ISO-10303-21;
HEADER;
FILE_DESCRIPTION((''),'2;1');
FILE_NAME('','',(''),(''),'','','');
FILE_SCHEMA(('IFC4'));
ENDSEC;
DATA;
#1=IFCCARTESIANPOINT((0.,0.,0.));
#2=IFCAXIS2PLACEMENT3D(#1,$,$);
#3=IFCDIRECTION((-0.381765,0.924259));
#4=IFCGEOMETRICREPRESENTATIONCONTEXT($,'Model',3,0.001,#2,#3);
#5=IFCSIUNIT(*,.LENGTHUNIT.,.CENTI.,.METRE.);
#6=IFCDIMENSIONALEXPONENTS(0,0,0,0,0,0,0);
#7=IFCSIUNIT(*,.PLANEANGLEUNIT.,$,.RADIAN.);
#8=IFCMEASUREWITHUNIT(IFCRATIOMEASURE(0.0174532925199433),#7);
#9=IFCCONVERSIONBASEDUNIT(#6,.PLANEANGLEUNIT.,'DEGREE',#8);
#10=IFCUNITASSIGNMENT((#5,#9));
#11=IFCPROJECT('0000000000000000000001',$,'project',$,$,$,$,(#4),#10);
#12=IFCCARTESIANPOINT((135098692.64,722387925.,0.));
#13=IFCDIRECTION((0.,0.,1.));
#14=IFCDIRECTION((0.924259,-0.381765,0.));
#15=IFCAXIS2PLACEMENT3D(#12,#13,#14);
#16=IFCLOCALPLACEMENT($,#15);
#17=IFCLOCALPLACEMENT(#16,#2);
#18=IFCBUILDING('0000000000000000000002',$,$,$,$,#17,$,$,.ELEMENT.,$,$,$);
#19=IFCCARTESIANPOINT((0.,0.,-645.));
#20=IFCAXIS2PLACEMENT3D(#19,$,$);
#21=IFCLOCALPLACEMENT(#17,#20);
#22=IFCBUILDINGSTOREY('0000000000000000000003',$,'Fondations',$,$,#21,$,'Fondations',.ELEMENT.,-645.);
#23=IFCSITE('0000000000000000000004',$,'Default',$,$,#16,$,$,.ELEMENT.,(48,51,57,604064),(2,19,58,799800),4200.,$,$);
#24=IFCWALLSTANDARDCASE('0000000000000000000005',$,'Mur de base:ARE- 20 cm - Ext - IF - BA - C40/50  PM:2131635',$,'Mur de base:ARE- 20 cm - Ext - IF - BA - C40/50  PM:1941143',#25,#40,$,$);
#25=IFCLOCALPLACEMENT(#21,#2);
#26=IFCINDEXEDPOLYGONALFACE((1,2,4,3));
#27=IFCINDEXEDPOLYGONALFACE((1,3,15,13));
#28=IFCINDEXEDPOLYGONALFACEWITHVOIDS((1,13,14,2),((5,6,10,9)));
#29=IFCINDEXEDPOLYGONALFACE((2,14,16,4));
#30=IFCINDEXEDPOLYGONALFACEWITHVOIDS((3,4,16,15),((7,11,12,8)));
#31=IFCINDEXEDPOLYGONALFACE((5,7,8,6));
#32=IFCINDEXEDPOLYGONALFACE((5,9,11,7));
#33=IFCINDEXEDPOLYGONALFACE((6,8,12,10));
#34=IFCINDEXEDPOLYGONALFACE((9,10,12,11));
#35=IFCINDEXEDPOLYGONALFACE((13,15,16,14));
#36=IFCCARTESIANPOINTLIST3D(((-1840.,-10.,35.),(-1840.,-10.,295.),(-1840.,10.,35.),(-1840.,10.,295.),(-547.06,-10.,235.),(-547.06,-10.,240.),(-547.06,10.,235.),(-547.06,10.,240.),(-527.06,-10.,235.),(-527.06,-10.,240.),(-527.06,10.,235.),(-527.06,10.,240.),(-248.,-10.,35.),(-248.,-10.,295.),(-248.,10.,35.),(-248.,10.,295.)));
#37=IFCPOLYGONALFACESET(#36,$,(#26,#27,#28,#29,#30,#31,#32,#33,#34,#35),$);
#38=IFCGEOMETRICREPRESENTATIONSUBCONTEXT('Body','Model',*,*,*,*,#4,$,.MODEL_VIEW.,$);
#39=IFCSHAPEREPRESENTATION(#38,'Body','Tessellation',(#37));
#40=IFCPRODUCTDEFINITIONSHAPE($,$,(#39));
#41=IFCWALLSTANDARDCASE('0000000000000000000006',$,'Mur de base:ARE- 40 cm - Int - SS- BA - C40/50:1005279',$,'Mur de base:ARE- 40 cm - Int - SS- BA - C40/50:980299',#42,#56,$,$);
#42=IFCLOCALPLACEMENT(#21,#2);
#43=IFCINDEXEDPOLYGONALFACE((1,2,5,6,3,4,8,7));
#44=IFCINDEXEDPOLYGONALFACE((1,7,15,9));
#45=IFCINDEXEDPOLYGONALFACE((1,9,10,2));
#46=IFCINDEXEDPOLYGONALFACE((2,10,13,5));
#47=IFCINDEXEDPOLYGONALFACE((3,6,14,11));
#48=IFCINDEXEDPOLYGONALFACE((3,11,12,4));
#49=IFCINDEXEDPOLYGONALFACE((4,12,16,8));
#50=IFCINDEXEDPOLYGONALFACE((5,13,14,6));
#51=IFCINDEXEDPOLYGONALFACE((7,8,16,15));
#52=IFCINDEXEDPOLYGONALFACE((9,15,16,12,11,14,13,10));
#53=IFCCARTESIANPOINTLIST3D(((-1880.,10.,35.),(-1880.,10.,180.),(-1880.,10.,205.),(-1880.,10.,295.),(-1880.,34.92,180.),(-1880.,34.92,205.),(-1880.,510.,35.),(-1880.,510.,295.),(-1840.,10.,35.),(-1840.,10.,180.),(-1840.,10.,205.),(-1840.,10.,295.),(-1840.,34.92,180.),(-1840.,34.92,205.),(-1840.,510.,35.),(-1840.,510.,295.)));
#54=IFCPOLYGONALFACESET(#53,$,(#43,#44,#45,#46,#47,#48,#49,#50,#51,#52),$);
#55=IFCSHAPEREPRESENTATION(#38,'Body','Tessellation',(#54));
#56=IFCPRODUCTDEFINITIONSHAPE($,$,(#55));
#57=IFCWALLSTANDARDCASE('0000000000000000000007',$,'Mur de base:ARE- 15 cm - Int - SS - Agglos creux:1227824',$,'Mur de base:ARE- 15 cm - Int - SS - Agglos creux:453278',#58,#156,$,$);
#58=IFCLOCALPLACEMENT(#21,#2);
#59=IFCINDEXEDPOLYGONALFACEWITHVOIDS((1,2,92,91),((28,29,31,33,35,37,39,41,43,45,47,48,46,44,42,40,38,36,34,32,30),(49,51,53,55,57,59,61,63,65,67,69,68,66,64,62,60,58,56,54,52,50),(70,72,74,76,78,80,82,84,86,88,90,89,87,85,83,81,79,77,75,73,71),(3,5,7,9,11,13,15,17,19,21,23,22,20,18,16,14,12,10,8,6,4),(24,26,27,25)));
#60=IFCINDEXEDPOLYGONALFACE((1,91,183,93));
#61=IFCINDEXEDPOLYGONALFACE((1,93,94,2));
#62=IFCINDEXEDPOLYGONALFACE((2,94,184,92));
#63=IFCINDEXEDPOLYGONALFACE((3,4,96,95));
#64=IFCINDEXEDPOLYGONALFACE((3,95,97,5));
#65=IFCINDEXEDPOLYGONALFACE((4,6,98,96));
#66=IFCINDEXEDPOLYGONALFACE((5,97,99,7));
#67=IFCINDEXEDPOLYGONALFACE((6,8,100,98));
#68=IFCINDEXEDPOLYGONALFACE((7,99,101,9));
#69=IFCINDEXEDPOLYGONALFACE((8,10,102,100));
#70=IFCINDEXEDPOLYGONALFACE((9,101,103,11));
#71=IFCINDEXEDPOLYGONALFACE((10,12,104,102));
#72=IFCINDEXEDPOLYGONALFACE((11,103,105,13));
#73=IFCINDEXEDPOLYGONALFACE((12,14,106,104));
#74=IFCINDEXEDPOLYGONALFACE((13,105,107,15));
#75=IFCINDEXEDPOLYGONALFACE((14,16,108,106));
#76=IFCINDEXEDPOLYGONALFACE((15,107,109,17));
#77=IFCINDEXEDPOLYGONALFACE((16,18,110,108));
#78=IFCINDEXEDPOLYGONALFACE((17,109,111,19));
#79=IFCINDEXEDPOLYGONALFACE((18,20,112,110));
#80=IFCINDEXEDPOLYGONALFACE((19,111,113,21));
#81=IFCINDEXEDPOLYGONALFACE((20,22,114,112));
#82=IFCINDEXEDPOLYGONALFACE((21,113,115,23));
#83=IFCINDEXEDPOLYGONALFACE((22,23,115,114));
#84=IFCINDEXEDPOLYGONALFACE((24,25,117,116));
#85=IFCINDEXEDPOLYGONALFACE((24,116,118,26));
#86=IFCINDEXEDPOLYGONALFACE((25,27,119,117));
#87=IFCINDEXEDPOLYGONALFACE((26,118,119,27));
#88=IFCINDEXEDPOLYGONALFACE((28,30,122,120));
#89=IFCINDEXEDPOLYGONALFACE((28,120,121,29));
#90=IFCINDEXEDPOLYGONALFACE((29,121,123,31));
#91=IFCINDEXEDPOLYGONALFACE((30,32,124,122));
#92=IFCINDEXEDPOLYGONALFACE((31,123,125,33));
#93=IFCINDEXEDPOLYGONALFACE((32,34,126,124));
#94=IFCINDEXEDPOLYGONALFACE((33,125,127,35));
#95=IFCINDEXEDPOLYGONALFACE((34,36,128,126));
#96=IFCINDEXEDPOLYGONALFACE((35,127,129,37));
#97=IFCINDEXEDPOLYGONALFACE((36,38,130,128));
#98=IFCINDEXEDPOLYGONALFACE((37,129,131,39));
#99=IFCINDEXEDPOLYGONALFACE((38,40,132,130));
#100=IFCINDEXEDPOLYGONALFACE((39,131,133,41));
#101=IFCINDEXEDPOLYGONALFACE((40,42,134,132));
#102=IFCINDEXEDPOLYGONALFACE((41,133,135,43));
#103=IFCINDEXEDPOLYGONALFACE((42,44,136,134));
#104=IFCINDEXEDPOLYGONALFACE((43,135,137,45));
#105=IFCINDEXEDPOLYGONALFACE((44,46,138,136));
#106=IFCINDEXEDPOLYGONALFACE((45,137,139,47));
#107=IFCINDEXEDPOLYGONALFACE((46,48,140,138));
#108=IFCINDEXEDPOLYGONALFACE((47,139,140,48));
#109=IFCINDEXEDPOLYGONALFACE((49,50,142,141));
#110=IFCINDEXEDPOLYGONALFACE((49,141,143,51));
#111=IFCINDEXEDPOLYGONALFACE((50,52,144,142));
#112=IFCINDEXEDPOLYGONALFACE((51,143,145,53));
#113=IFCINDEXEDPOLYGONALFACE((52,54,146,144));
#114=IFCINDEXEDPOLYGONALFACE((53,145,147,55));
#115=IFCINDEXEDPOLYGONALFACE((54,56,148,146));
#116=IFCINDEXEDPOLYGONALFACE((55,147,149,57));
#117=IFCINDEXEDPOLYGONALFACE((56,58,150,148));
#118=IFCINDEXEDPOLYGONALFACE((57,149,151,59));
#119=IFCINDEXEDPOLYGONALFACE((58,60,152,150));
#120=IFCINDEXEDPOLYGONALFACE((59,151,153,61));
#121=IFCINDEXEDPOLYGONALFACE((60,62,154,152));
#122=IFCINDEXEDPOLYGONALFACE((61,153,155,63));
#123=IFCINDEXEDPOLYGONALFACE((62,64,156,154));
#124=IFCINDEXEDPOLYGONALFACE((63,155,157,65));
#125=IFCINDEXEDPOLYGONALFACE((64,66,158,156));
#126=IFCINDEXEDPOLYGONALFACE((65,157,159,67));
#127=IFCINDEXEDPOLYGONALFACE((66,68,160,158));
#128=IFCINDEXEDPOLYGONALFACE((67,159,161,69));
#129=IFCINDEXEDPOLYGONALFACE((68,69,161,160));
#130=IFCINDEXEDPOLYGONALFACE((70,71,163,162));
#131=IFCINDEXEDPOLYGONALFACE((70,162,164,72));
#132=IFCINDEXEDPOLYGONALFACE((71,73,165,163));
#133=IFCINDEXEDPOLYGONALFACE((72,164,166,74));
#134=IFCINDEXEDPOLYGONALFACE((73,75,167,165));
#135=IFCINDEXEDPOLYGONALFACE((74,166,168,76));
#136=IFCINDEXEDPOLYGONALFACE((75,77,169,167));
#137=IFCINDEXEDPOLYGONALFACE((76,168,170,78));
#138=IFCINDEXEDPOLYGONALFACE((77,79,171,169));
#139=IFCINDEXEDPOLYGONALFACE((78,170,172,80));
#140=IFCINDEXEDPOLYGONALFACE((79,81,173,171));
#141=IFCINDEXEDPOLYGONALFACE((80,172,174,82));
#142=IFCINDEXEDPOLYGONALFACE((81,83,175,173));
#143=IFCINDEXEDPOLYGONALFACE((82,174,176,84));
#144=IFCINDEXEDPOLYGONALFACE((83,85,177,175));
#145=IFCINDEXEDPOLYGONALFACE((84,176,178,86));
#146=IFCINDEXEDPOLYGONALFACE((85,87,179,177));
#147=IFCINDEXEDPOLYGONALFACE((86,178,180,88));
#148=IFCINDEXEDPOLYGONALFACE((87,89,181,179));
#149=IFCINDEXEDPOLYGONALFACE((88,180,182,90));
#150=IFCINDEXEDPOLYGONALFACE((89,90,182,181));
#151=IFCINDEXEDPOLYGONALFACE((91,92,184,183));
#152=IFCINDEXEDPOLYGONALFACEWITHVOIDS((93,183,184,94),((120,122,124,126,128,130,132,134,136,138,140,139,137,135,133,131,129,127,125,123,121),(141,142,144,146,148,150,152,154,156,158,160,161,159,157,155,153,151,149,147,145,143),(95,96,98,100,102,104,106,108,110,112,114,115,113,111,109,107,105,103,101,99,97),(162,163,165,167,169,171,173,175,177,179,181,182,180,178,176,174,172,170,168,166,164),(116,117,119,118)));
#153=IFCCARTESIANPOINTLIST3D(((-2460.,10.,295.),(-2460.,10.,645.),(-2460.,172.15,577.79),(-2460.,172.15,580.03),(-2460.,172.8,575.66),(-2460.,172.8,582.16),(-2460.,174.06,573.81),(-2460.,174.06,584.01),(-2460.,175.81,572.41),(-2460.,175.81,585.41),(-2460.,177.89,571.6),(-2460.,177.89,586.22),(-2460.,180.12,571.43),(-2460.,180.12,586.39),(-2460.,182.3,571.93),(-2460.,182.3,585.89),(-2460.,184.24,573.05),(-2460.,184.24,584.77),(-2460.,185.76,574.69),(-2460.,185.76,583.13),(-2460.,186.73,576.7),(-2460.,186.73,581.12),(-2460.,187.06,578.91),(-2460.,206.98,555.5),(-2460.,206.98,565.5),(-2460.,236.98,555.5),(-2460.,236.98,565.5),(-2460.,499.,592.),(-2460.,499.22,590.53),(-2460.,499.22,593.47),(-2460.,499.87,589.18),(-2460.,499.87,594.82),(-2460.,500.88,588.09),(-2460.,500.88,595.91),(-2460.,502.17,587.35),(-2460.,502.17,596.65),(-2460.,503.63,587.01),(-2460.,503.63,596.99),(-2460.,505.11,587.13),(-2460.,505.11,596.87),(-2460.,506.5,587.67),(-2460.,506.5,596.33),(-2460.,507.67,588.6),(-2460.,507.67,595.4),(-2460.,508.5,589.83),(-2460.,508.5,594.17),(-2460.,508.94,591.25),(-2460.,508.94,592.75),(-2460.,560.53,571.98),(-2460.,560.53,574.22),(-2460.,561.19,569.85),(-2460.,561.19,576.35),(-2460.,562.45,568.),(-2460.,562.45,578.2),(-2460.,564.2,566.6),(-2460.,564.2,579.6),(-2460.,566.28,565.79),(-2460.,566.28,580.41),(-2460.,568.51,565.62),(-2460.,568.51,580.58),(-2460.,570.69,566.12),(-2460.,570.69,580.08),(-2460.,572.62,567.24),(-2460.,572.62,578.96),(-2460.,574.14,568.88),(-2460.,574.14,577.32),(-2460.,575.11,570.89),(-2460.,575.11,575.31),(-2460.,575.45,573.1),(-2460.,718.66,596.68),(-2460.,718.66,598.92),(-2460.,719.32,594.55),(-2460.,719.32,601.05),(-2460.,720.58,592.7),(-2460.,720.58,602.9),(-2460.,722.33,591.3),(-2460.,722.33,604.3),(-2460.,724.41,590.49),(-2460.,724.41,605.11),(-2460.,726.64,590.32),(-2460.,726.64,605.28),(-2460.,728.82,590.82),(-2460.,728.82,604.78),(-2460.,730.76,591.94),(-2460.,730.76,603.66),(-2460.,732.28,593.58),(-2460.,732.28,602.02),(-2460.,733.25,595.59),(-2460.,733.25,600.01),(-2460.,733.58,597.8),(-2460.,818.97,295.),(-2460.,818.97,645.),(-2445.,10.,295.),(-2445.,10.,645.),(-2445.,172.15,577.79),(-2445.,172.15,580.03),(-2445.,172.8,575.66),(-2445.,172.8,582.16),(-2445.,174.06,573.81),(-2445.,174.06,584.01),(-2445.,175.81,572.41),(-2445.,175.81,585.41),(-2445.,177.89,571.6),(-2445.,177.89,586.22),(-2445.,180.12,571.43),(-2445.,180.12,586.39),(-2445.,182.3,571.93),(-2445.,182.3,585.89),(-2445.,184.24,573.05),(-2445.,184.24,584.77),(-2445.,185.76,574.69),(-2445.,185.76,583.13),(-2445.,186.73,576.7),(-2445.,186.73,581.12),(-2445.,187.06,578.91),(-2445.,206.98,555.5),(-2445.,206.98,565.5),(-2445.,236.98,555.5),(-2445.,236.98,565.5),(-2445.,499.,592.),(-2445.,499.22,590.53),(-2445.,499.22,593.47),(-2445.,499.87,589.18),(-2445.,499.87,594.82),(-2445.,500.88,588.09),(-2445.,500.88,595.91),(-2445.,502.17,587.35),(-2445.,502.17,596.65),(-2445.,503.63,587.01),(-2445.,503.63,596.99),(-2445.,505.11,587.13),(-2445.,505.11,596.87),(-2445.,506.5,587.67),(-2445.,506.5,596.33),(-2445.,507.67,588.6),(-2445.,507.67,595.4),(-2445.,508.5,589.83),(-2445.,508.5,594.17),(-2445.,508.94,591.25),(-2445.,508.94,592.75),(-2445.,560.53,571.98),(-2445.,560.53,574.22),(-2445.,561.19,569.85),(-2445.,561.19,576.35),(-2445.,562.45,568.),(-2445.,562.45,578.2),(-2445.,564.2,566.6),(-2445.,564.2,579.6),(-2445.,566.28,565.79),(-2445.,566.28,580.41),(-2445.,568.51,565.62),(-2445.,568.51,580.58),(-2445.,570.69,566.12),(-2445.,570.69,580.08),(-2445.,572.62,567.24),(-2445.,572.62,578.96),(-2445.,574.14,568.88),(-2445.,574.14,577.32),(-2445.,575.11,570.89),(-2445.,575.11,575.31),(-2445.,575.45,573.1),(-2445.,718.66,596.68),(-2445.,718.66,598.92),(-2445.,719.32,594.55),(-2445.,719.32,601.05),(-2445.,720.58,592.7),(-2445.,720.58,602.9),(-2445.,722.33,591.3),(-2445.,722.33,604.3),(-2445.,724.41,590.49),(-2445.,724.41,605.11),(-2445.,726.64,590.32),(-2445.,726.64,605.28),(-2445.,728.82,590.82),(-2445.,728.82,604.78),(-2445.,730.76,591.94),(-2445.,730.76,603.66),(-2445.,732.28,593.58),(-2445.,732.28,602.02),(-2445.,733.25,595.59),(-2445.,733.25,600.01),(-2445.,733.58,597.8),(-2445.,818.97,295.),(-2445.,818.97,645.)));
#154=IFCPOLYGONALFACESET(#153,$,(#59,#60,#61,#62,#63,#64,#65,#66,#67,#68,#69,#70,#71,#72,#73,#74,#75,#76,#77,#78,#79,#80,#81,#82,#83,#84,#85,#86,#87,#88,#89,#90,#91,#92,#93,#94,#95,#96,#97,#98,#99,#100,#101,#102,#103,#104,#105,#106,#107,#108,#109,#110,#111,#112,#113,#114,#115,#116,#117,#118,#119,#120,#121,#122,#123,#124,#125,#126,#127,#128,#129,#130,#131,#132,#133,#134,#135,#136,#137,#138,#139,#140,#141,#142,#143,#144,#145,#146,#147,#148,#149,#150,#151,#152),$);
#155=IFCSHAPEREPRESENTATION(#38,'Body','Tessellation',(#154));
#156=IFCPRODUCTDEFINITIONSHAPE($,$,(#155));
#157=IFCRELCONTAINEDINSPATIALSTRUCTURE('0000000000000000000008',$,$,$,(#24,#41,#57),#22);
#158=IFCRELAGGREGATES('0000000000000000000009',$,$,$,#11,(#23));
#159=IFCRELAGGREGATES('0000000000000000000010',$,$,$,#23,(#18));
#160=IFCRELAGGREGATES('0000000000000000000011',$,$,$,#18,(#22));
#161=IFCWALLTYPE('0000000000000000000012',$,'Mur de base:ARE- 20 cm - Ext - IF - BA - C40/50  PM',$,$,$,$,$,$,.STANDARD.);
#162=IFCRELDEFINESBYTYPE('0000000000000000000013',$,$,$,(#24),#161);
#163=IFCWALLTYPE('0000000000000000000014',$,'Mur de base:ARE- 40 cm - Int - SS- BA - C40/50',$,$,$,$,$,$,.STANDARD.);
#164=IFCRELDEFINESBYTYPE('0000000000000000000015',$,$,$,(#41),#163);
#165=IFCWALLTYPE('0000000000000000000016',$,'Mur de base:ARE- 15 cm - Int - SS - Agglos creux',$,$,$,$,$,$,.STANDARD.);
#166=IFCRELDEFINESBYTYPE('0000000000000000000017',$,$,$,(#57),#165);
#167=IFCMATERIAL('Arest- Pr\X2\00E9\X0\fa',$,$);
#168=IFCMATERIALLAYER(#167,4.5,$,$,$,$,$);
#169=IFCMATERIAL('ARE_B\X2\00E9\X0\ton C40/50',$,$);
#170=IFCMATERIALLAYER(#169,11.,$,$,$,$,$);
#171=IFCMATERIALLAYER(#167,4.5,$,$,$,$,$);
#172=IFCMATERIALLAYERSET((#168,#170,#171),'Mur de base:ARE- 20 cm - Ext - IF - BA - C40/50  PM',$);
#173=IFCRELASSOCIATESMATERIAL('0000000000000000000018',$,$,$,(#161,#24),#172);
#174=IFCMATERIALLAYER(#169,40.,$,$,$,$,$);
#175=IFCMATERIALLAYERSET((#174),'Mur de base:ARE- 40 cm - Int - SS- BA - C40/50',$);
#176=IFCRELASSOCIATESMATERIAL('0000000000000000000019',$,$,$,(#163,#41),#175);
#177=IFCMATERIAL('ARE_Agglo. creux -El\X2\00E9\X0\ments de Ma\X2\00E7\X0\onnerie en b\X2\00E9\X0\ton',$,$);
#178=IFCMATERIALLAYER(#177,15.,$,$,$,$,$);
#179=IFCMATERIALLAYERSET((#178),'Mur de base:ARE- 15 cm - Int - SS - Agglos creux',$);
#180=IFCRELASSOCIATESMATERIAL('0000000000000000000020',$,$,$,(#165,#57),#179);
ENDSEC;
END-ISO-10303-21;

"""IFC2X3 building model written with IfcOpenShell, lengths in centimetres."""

from ifc_helpers import new_model, entity, si_unit, converted_unit, direction, frame, frame_2d, origin, place, context, subcontext, project, spatial, rectangle, circle, extrude, material, layer, layer_set, layer_usage, type_object, element, save


model = new_model("IFC2X3")

# Units and contexts
model_context = context("Model", 3, precision=0.001, world=origin(), true_north=direction((-0.381765, 0.924259)))
body_context = subcontext(model_context, "Body", "Model", "MODEL_VIEW")
ifc_project = project(units=[si_unit("LENGTHUNIT", "METRE", prefix="CENTI"), converted_unit("PLANEANGLEUNIT", "DEGREE", entity("IfcRatioMeasure", 0.0174532925199433), si_unit("PLANEANGLEUNIT", "RADIAN"), dimensions=[0, 0, 0, 0, 0, 0, 0])], contexts=[model_context])

# Site, building, storey
site_placement = place(None, frame((135098692.64, 722387925.0, 0.0), z_axis=(0.0, 0.0, 1.0), x_axis=(0.924259, -0.381765, 0.0)))
site = spatial("IfcSite", under=ifc_project, at=site_placement, Name="Default", CompositionType="ELEMENT", RefLatitude=(48, 51, 57, 604064), RefLongitude=(2, 19, 58, 799800), RefElevation=4200.0)
building_placement = place(site_placement, origin())
building = spatial("IfcBuilding", under=site, at=building_placement, CompositionType="ELEMENT")
storey_placement = place(building_placement, frame((0.0, 0.0, -645.0)))
storey = spatial("IfcBuildingStorey", under=building, at=storey_placement, Name="Fondations", LongName="Fondations", CompositionType="ELEMENT", Elevation=-645.0)

# Shared definitions
ifc_material_1 = material(Name="ARE_Béton C40/50")

# Shared definitions
ifc_material_2 = material(Name="Arest- Préfa")
ifc_layer_1 = layer(ifc_material_2, 4.5)
ifc_layer_2 = layer(ifc_material_1, 11.0)
ifc_layer_3 = layer(ifc_material_2, 4.5)
ifc_layer_set_1 = layer_set([ifc_layer_1, ifc_layer_2, ifc_layer_3], Name="Mur de base:ARE- 20 cm - Ext - IF - BA - C40/50  PM")
wall_type_1 = type_object("IfcWallType", Name="Mur de base:ARE- 20 cm - Ext - IF - BA - C40/50  PM", PredefinedType="STANDARD", material=ifc_layer_set_1)

# Walls, openings
ifc_layer_usage_1 = layer_usage(ifc_layer_set_1, "AXIS2", "NEGATIVE", 10.0)
wall_1_placement = place(storey_placement, frame((-1840.0, 0.0, 35.0)))
wall_1 = element("IfcWallStandardCase", 1, at=wall_1_placement, inside=storey, type_object=wall_type_1, material=ifc_layer_usage_1, Name="Mur de base:ARE- 20 cm - Ext - IF - BA - C40/50  PM:2131635", ObjectType="Mur de base:ARE- 20 cm - Ext - IF - BA - C40/50  PM:1941143", context=body_context, shape_type="SweptSolid", body=[
    extrude(rectangle(XDim=1592.0, YDim=20.0, at=frame_2d((796.0, 0.0), x_axis=(-1.0, 0.0))), origin(), (0.0, 0.0, 1.0), 260.0),
])
opening_1_placement = place(wall_1_placement, origin())
element("IfcOpeningElement", 2, at=opening_1_placement, cuts=wall_1, ObjectType="Opening", context=body_context, shape_type="SweptSolid", body=[
    extrude(rectangle(XDim=5.0, YDim=20.0, at=frame_2d((0.0, 0.0), x_axis=(0.0, 1.0))), frame((1302.94, -10.0, 202.5), z_axis=(0.0, 1.0, 0.0), x_axis=(1.0, 0.0, 0.0)), (0.0, 0.0, 1.0), 20.0),
])
ifc_layer_4 = layer(ifc_material_1, 40.0)
ifc_layer_set_2 = layer_set([ifc_layer_4], Name="Mur de base:ARE- 40 cm - Int - SS- BA - C40/50")
ifc_layer_usage_2 = layer_usage(ifc_layer_set_2, "AXIS2", "NEGATIVE", 20.0)
wall_type_2 = type_object("IfcWallType", Name="Mur de base:ARE- 40 cm - Int - SS- BA - C40/50", PredefinedType="STANDARD", material=ifc_layer_set_2)
wall_2_placement = place(storey_placement, frame((-1860.0, 510.0, 35.0), z_axis=(0.0, 0.0, 1.0), x_axis=(0.0, -1.0, 0.0)))
wall_2 = element("IfcWallStandardCase", 3, at=wall_2_placement, inside=storey, type_object=wall_type_2, material=ifc_layer_usage_2, Name="Mur de base:ARE- 40 cm - Int - SS- BA - C40/50:1005279", ObjectType="Mur de base:ARE- 40 cm - Int - SS- BA - C40/50:980299", context=body_context, shape_type="SweptSolid", body=[
    extrude(rectangle(XDim=500.0, YDim=40.0, at=frame_2d((250.0, 0.0), x_axis=(-1.0, 0.0))), origin(), (0.0, 0.0, 1.0), 260.0),
])
opening_2_placement = place(wall_2_placement, origin())
element("IfcOpeningElement", 4, at=opening_2_placement, cuts=wall_2, ObjectType="Opening", context=body_context, shape_type="SweptSolid", body=[
    extrude(rectangle(XDim=25.0, YDim=25.0, at=frame_2d((0.0, 0.0), x_axis=(0.0, 1.0))), frame((487.58, -20.0, 157.5), z_axis=(0.0, 1.0, 0.0), x_axis=(1.0, 0.0, 0.0)), (0.0, 0.0, 1.0), 40.0),
])

# Wall, openings
ifc_material_3 = material(Name="ARE_Agglo. creux -Eléments de Maçonnerie en béton")
ifc_layer_5 = layer(ifc_material_3, 15.0)
ifc_layer_set_3 = layer_set([ifc_layer_5], Name="Mur de base:ARE- 15 cm - Int - SS - Agglos creux")
ifc_layer_usage_3 = layer_usage(ifc_layer_set_3, "AXIS2", "NEGATIVE", 7.5)
wall_type_3 = type_object("IfcWallType", Name="Mur de base:ARE- 15 cm - Int - SS - Agglos creux", PredefinedType="STANDARD", material=ifc_layer_set_3)
wall_3_placement = place(storey_placement, frame((-2452.5, 818.97, 295.0), z_axis=(0.0, 0.0, 1.0), x_axis=(0.0, -1.0, 0.0)))
wall_3 = element("IfcWallStandardCase", 5, at=wall_3_placement, inside=storey, type_object=wall_type_3, material=ifc_layer_usage_3, Name="Mur de base:ARE- 15 cm - Int - SS - Agglos creux:1227824", ObjectType="Mur de base:ARE- 15 cm - Int - SS - Agglos creux:453278", context=body_context, shape_type="SweptSolid", body=[
    extrude(rectangle(XDim=808.97, YDim=15.0, at=frame_2d((404.49, 0.0), x_axis=(-1.0, 0.0))), origin(), (0.0, 0.0, 1.0), 350.0),
])
opening_3_placement = place(wall_3_placement, origin())
element("IfcOpeningElement", 6, at=opening_3_placement, cuts=wall_3, ObjectType="Opening", context=body_context, shape_type="SweptSolid", body=[
    extrude(rectangle(XDim=10.0, YDim=30.0, at=frame_2d((0.0, 0.0), x_axis=(1.0, 0.0))), frame((596.99, -7.5, 265.5), z_axis=(0.0, 1.0, 0.0), x_axis=(0.0, 0.0, -1.0)), (0.0, 0.0, 1.0), 15.0),
])
opening_4_placement = place(wall_3_placement, origin())
element("IfcOpeningElement", 7, at=opening_4_placement, cuts=wall_3, ObjectType="Opening", context=body_context, shape_type="SweptSolid", body=[
    extrude(circle(Radius=7.5, at=frame_2d((0.0, 0.0), x_axis=(1.0, 0.0))), frame((639.41, -7.5, 283.91), z_axis=(0.0, 1.0, 0.0), x_axis=(-1.0, 0.0, 0.0)), (0.0, 0.0, 1.0), 15.0),
])
opening_5_placement = place(wall_3_placement, origin())
element("IfcOpeningElement", 8, at=opening_5_placement, cuts=wall_3, ObjectType="Opening", context=body_context, shape_type="SweptSolid", body=[
    extrude(circle(Radius=5.0, at=frame_2d((0.0, 0.0), x_axis=(1.0, 0.0))), frame((314.97, -7.5, 297.0), z_axis=(0.0, 1.0, 0.0), x_axis=(1.0, 0.0, 0.0)), (0.0, 0.0, 1.0), 15.0),
])
opening_6_placement = place(wall_3_placement, origin())
element("IfcOpeningElement", 9, at=opening_6_placement, cuts=wall_3, ObjectType="Opening", context=body_context, shape_type="SweptSolid", body=[
    extrude(circle(Radius=7.5, at=frame_2d((0.0, 0.0), x_axis=(1.0, 0.0))), frame((251.02, -7.5, 278.1), z_axis=(0.0, 1.0, 0.0), x_axis=(-1.0, 0.0, 0.0)), (0.0, 0.0, 1.0), 15.0),
])
opening_7_placement = place(wall_3_placement, origin())
element("IfcOpeningElement", 10, at=opening_7_placement, cuts=wall_3, ObjectType="Opening", context=body_context, shape_type="SweptSolid", body=[
    extrude(circle(Radius=7.5, at=frame_2d((0.0, 0.0), x_axis=(1.0, 0.0))), frame((92.89, -7.5, 302.8), z_axis=(0.0, 1.0, 0.0), x_axis=(-1.0, 0.0, 0.0)), (0.0, 0.0, 1.0), 15.0),
])

save(model, "model.ifc")
